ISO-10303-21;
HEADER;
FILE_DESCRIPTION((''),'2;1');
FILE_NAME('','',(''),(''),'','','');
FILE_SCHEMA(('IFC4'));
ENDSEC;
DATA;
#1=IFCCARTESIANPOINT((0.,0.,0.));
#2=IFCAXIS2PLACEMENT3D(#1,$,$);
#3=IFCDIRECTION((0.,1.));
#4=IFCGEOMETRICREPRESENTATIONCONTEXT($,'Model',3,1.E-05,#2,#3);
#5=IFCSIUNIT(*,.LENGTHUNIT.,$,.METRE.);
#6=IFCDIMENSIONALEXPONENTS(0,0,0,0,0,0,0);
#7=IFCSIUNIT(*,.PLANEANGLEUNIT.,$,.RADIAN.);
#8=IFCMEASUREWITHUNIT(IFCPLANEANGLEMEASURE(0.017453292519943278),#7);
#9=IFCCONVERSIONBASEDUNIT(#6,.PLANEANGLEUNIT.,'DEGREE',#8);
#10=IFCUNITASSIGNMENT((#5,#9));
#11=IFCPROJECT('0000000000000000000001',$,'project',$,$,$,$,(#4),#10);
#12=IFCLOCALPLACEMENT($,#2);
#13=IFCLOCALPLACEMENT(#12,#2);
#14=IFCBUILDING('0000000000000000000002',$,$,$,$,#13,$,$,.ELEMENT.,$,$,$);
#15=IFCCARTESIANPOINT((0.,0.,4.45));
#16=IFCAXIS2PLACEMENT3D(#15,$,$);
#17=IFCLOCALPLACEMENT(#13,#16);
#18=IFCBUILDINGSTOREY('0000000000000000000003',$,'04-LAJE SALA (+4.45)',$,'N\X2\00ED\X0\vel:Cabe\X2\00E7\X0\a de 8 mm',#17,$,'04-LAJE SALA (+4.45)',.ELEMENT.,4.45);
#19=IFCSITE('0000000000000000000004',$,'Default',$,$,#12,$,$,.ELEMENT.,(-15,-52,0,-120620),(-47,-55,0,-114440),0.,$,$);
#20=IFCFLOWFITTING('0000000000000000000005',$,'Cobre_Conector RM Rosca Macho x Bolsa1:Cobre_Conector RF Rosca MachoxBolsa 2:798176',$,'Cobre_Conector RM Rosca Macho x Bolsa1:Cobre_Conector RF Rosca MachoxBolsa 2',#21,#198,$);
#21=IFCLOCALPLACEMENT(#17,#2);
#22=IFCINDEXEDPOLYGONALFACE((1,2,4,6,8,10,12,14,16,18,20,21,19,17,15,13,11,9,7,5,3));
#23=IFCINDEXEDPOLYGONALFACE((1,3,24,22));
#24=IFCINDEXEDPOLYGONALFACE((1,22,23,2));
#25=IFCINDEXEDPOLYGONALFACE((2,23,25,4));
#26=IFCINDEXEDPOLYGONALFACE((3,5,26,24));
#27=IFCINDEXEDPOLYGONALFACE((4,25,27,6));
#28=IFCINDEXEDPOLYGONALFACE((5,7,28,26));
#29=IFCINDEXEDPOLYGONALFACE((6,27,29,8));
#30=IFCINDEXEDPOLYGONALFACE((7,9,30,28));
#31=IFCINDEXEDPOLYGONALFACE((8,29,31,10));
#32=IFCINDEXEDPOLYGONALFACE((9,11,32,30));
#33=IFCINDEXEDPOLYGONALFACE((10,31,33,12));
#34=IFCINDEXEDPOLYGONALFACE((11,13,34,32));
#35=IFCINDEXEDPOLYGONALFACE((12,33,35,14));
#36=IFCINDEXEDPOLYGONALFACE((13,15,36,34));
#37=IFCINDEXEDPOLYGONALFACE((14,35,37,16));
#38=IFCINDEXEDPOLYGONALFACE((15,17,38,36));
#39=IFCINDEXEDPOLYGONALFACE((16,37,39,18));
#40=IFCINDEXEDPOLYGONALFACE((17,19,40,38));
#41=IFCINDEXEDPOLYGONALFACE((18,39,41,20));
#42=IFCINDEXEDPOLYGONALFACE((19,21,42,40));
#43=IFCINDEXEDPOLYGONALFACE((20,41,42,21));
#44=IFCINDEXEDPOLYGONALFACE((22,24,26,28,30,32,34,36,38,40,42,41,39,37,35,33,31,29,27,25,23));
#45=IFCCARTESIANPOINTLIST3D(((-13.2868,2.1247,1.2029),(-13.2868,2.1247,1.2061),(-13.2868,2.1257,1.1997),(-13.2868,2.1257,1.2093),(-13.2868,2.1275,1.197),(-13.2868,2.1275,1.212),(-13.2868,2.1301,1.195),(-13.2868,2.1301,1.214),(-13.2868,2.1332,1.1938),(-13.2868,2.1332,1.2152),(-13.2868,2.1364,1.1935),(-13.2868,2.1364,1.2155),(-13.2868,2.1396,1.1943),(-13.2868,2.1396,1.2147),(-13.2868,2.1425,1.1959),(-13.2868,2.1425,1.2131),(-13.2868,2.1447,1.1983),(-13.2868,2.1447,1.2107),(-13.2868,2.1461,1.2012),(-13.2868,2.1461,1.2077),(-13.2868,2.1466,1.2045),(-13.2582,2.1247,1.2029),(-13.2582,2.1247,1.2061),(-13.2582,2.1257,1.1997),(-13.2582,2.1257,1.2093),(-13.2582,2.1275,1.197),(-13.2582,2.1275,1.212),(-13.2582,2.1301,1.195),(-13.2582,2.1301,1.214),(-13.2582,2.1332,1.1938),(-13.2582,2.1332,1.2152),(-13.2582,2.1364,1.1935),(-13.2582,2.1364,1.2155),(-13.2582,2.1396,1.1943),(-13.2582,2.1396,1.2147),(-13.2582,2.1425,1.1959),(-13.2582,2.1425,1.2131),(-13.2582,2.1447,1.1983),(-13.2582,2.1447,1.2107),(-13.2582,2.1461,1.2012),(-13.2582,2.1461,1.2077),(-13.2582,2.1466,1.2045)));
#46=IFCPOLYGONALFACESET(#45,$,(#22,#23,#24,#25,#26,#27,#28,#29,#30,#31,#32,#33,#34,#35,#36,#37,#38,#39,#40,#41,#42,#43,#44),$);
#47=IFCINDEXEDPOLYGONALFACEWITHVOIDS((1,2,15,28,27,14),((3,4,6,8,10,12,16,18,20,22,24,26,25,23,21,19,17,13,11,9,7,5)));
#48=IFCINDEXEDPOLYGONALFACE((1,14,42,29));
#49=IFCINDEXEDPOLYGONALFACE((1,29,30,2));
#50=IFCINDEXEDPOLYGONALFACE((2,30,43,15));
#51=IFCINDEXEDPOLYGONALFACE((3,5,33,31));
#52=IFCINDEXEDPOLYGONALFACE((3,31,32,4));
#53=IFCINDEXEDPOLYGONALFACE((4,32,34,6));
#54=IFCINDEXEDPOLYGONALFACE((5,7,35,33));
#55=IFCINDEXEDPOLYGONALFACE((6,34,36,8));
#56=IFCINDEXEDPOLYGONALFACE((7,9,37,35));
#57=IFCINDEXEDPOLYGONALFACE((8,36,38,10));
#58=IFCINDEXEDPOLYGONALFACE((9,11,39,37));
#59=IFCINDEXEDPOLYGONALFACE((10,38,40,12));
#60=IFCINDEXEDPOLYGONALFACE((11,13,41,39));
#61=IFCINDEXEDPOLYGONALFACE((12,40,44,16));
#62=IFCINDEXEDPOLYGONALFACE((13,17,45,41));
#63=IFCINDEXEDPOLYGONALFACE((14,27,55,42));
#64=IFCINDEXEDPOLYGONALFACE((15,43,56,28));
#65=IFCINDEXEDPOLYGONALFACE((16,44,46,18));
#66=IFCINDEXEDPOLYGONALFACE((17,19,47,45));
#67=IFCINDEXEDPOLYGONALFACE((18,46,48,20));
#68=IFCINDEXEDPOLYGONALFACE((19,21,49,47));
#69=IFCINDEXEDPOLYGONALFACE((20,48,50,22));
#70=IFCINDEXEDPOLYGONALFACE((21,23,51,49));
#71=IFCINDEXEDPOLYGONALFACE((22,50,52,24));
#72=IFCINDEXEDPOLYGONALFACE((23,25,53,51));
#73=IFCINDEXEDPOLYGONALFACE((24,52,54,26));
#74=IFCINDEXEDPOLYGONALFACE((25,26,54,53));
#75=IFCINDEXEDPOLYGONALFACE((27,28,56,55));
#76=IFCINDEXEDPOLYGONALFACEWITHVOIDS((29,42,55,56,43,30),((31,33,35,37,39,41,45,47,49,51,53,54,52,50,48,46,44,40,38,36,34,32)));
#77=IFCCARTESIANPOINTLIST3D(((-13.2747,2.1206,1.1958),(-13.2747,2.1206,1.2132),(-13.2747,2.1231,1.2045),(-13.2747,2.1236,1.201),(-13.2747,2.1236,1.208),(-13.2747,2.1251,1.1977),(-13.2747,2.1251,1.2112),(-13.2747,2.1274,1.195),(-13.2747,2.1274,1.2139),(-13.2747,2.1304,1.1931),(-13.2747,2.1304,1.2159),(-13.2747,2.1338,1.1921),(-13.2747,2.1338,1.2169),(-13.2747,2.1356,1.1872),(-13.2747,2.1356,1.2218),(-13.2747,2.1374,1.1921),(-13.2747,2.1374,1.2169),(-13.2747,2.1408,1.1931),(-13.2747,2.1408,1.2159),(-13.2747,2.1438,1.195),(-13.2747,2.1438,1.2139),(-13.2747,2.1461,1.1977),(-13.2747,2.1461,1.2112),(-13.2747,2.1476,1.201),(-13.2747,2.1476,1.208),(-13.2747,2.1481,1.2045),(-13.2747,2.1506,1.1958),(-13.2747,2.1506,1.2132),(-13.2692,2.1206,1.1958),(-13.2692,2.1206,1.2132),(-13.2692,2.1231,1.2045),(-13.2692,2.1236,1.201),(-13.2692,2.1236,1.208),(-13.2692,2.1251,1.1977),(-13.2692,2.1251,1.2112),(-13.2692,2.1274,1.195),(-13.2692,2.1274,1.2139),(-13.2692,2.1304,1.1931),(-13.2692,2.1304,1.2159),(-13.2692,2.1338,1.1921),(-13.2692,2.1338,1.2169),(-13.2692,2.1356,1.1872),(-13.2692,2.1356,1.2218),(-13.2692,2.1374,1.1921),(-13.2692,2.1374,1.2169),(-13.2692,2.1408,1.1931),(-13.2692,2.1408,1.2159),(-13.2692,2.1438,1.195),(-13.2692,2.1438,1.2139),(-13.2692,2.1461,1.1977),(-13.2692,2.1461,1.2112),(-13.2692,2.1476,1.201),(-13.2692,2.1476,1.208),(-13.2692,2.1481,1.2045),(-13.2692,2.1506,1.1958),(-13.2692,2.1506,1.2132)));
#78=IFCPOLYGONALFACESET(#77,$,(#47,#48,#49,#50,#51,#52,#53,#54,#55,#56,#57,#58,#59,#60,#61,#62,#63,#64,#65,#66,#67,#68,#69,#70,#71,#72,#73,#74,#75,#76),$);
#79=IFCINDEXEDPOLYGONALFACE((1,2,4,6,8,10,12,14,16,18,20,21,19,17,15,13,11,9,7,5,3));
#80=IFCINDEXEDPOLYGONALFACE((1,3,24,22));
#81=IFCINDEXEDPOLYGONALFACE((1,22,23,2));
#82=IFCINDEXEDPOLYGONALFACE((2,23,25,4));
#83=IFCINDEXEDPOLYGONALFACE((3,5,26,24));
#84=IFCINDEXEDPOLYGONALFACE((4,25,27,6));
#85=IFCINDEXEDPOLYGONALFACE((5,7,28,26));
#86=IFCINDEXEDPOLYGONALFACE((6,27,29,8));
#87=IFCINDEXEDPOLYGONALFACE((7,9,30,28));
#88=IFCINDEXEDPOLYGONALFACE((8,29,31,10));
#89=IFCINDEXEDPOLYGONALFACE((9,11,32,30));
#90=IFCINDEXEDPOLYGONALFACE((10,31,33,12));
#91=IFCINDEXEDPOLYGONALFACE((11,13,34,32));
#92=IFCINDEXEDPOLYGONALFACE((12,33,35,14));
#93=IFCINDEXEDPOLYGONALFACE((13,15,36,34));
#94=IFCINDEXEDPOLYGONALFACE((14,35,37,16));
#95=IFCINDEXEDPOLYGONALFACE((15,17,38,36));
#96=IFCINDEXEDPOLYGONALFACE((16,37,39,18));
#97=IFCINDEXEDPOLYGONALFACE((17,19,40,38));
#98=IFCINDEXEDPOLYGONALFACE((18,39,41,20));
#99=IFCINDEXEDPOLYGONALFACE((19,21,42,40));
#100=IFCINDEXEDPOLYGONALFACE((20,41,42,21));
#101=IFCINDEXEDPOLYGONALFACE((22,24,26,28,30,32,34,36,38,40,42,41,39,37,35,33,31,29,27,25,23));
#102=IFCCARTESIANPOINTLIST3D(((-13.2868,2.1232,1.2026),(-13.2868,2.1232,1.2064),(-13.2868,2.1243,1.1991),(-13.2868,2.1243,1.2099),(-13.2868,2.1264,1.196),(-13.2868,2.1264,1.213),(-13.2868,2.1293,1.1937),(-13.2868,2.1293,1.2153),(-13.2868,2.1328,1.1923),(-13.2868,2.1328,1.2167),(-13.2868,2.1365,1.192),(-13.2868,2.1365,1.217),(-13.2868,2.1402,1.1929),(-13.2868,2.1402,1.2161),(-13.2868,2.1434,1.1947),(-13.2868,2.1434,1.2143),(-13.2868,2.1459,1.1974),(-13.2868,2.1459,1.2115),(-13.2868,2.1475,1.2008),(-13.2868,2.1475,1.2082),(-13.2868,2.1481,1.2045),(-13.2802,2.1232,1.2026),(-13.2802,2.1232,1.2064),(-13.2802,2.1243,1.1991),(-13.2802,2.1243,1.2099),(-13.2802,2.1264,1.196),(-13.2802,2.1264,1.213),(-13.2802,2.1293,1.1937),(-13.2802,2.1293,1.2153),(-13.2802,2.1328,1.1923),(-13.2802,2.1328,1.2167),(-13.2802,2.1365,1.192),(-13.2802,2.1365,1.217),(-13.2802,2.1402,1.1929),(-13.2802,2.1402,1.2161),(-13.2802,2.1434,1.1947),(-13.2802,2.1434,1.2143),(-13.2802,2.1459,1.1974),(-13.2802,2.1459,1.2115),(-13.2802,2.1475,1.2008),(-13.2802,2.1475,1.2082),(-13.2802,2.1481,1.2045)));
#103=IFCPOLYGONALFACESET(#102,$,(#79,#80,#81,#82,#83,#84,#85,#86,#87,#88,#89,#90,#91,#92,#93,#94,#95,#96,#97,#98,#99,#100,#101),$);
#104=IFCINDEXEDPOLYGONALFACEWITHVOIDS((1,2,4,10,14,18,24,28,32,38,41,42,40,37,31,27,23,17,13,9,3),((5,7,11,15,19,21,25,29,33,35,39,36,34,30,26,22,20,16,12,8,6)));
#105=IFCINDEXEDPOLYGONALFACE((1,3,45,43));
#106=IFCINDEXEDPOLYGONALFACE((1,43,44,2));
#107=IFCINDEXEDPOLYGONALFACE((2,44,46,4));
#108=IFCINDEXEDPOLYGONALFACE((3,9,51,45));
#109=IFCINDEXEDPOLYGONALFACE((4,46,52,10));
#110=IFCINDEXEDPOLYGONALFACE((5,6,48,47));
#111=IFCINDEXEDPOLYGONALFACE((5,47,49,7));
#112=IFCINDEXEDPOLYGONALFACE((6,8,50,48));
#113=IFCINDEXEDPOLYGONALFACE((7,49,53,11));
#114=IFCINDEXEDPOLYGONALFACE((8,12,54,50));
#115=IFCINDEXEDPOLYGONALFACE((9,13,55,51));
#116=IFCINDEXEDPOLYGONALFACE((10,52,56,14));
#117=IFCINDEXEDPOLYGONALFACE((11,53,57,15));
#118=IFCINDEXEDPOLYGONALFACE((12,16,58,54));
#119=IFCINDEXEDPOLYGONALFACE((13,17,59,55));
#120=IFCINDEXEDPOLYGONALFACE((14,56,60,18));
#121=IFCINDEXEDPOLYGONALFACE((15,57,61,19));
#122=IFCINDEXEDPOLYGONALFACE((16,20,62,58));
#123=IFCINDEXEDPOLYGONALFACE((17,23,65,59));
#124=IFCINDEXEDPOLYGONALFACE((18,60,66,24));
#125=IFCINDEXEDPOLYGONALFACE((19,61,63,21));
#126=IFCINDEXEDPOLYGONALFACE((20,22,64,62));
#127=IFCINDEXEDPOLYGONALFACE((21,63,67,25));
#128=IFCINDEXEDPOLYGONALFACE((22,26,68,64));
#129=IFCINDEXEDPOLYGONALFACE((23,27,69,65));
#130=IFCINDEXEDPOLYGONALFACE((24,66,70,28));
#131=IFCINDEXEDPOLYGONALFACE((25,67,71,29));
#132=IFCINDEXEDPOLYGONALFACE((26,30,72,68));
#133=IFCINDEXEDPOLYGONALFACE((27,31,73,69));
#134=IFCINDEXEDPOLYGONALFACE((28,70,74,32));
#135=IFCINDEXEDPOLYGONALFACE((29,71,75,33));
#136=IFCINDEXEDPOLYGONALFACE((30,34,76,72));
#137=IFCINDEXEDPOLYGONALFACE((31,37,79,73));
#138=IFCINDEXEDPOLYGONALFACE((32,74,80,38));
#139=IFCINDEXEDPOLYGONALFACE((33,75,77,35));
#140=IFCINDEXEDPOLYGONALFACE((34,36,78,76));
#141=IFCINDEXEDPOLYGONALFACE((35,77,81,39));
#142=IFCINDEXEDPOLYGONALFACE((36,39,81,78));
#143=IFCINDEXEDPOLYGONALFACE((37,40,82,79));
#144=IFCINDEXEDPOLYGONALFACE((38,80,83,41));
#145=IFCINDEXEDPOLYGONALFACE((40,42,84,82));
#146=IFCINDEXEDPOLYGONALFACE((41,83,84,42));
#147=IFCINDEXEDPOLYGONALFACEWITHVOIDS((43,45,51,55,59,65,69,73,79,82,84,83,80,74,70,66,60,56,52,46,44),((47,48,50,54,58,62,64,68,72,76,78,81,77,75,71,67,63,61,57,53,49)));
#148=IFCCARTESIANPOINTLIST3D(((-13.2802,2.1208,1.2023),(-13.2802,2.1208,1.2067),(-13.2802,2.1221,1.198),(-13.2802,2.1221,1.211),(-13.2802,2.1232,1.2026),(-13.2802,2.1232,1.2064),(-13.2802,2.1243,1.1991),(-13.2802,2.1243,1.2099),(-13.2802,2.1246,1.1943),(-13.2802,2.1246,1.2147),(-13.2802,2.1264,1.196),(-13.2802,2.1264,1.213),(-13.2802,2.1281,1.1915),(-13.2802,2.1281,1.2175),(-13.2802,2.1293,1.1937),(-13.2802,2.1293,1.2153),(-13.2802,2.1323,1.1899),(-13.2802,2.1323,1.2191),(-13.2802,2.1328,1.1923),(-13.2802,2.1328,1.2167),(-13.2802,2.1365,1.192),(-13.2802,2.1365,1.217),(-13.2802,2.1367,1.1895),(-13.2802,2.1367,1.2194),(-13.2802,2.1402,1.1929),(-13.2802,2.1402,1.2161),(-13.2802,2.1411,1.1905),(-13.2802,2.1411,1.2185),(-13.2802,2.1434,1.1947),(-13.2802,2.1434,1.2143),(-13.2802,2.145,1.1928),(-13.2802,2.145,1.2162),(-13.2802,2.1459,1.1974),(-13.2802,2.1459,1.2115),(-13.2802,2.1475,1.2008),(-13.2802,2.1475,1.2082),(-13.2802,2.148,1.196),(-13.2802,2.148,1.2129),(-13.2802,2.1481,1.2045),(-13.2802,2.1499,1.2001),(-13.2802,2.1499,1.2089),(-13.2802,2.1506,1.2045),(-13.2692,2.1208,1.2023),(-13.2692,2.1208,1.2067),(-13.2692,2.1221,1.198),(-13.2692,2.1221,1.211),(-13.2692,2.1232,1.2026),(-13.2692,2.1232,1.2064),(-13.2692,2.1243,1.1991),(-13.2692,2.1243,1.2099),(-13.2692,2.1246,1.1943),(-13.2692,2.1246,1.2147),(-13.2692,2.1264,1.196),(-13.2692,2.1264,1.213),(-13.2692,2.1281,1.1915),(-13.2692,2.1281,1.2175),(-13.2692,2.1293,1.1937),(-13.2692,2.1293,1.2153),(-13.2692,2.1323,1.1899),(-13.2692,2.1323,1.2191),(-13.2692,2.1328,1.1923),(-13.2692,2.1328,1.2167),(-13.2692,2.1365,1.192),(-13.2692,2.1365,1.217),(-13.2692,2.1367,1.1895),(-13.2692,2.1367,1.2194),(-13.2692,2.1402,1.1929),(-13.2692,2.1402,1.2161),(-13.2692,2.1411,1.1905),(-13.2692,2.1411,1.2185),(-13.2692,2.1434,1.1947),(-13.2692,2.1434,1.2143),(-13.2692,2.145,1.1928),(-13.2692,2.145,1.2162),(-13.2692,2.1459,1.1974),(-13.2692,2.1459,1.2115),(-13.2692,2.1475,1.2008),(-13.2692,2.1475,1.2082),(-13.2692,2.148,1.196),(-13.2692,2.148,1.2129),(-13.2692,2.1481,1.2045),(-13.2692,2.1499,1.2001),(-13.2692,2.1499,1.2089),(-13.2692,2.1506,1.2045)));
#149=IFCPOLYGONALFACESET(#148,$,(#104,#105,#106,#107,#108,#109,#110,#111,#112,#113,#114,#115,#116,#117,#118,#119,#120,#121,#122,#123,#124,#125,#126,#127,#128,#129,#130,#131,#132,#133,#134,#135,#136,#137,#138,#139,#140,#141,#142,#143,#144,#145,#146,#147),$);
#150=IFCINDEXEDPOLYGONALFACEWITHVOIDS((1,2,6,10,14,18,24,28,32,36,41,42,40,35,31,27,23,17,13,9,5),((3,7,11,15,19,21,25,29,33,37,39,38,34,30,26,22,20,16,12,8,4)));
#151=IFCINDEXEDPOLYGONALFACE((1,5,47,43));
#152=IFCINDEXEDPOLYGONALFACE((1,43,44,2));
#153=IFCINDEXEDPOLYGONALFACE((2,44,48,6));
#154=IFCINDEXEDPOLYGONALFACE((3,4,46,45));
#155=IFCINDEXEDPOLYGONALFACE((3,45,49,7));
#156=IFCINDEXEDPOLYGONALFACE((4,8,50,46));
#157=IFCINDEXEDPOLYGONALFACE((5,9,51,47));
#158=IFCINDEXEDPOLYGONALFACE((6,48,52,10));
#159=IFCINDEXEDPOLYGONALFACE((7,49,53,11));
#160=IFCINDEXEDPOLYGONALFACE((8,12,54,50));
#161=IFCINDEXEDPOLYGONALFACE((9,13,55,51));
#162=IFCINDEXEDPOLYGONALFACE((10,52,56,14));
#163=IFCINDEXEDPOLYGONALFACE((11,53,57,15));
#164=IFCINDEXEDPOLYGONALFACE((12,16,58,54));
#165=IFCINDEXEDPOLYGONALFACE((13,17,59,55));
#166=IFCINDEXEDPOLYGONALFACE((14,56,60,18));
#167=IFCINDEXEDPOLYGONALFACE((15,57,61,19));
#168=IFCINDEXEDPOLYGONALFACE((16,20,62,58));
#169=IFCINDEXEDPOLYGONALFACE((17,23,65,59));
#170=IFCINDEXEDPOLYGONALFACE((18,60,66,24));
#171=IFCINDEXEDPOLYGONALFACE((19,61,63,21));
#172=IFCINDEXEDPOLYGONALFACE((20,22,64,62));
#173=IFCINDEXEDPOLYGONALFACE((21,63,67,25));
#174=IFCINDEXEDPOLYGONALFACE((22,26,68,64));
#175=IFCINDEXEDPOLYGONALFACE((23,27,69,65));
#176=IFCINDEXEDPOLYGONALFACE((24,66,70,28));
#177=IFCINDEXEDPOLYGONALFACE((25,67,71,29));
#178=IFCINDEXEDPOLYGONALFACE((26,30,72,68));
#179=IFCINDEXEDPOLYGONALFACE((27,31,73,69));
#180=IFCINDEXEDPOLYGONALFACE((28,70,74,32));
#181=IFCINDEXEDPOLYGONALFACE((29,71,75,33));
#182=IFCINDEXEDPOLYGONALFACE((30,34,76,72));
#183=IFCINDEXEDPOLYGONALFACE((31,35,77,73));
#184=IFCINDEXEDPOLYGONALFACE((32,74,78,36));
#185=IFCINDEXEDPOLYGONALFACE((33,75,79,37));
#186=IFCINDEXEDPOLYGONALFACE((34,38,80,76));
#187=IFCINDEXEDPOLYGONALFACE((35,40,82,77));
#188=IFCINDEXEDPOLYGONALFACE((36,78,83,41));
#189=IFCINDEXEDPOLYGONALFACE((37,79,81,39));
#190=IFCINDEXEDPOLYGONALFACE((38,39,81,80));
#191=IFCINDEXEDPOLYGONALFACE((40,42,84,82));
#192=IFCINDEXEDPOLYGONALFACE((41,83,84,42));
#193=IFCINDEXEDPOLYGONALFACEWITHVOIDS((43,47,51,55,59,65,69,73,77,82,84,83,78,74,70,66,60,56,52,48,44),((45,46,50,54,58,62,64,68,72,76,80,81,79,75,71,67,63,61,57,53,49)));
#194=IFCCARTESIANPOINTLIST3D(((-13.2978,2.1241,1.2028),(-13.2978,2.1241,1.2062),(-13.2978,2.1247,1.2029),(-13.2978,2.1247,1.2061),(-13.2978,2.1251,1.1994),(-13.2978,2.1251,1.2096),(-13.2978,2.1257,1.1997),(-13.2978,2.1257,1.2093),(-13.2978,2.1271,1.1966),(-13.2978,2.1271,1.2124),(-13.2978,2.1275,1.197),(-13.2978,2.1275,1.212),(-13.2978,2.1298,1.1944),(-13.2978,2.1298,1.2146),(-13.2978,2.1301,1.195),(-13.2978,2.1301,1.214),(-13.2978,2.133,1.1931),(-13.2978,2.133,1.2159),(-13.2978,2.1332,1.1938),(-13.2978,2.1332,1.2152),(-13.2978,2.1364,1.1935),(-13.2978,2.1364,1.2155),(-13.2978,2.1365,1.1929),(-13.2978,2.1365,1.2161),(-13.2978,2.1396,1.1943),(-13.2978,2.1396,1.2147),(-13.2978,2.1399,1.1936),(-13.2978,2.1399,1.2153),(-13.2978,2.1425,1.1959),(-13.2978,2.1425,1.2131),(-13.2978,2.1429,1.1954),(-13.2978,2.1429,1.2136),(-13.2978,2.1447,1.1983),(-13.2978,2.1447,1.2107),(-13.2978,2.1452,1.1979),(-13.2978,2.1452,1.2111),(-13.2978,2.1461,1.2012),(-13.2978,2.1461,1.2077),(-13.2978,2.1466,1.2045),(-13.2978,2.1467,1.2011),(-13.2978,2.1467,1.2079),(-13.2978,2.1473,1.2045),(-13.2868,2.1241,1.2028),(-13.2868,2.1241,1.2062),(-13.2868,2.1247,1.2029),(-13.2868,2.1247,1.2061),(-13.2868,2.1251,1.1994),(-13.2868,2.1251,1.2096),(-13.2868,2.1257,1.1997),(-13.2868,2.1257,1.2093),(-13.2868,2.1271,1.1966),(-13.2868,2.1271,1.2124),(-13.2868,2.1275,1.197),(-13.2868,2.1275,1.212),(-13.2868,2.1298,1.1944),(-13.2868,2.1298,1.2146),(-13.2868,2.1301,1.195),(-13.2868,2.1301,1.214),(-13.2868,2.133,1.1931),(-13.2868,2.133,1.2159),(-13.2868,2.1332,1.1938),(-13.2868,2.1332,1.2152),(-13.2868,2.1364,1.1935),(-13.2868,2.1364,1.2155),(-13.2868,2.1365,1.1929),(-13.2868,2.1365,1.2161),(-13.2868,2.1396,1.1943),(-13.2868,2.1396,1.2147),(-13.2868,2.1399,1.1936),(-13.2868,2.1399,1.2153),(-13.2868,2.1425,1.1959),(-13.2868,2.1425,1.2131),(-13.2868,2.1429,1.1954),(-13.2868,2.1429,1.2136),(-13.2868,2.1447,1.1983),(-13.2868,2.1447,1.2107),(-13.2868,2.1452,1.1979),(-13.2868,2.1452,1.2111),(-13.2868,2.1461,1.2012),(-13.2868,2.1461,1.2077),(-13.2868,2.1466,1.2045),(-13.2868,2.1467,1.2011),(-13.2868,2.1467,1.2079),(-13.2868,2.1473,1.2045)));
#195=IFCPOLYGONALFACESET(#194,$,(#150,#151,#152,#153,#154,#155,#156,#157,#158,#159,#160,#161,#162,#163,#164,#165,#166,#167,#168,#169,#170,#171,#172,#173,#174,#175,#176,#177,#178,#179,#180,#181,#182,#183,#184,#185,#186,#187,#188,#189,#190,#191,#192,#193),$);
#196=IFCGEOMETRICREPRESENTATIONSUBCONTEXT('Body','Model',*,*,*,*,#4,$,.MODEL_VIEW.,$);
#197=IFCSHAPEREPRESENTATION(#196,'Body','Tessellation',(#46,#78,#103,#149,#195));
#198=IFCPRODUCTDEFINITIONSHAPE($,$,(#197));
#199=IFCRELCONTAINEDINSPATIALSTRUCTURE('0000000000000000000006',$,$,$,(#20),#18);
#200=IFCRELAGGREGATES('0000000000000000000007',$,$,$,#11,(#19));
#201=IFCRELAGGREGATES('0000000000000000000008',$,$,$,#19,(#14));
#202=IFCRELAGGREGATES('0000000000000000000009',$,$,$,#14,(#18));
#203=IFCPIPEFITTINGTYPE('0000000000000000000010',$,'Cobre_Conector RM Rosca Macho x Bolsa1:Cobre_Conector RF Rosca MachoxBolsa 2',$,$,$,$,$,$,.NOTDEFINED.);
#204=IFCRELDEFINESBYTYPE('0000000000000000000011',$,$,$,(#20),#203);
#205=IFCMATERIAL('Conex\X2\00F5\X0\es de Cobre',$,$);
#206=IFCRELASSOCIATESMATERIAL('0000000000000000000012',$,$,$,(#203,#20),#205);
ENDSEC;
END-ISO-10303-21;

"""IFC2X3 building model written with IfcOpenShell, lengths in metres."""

from ifc_helpers import new_model, entity, si_unit, converted_unit, direction, frame, frame_2d, origin, place, context, subcontext, project, spatial, polyline, circle_curve, parameter, trimmed, segment, composite_curve, circle, hollow_circle, outline, extrude, source, transform, mapped, material, type_object, type_shapes, element, save


model = new_model("IFC2X3")

# Units and contexts
model_context = context("Model", 3, precision=1e-05, world=origin(), true_north=direction((0.0, 1.0)))
body_context = subcontext(model_context, "Body", "Model", "MODEL_VIEW")
ifc_project = project(units=[si_unit("LENGTHUNIT", "METRE"), converted_unit("PLANEANGLEUNIT", "DEGREE", entity("IfcPlaneAngleMeasure", 0.017453292519943278), si_unit("PLANEANGLEUNIT", "RADIAN"), dimensions=[0, 0, 0, 0, 0, 0, 0])], contexts=[model_context])

# Site, building, storey
site_placement = place(None, origin())
site = spatial("IfcSite", under=ifc_project, at=site_placement, Name="Default", CompositionType="ELEMENT", RefLatitude=(-15, -52, 0, -120620), RefLongitude=(-47, -55, 0, -114440), RefElevation=0.0)
building_placement = place(site_placement, origin())
building = spatial("IfcBuilding", under=site, at=building_placement, CompositionType="ELEMENT")
storey_placement = place(building_placement, frame((0.0, 0.0, 4.45)))
storey = spatial("IfcBuildingStorey", under=building, at=storey_placement, Name="04-LAJE SALA (+4.45)", ObjectType="Nível:Cabeça de 8 mm", LongName="04-LAJE SALA (+4.45)", CompositionType="ELEMENT", Elevation=4.45)

# Flow fitting
ifc_material_1 = material(Name="Conexões de Cobre")
pipe_fitting_type_1 = type_object("IfcPipeFittingType", Name="Cobre_Conector RM Rosca Macho x Bolsa1:Cobre_Conector RF Rosca MachoxBolsa 2", PredefinedType="NOTDEFINED", material=ifc_material_1)
shared_shape_1 = source(origin(), body_context, "Body", "SweptSolid", [
    extrude(circle(Radius=0.011, at=frame_2d((0.0, 0.0), x_axis=(1.0, 0.0))), frame((0.011, 0.0, 0.0), z_axis=(1.0, 0.0, 0.0), x_axis=(0.0, 1.0, 0.0)), (0.0, 0.0, 1.0), 0.0286),
    extrude(outline(polyline([(-0.0087, -0.015), (0.0087, -0.015), (0.0173, 0.0), (0.0087, 0.015), (-0.0087, 0.015), (-0.0173, 0.0), (-0.0087, -0.015)]), holes=[composite_curve([segment(trimmed(circle_curve(frame_2d((0.0, 0.0), x_axis=(0.0, 1.0)), 0.0125), [parameter(0.0)], [parameter(180.0)], True, "PARAMETER"), False, "CONTINUOUS"), segment(trimmed(circle_curve(frame_2d((0.0, 0.0), x_axis=(0.0, 1.0)), 0.0125), [parameter(180.0)], [parameter(0.0)], True, "PARAMETER"), False, "CONTINUOUS")], self_intersect=False)]), frame((0.0231, 0.0, 0.0), z_axis=(1.0, 0.0, 0.0), x_axis=(0.0, 0.0, -1.0)), (0.0, 0.0, 1.0), 0.0055),
    extrude(circle(Radius=0.0125, at=frame_2d((0.0, 0.0), x_axis=(1.0, 0.0))), frame((0.011, 0.0, 0.0), z_axis=(1.0, 0.0, 0.0), x_axis=(0.0, 1.0, 0.0)), (0.0, 0.0, 1.0), 0.0066),
    extrude(hollow_circle(Radius=0.015, WallThickness=0.0025, at=frame_2d((0.0, 0.0), x_axis=(1.0, 0.0))), frame((0.0176, 0.0, 0.0), z_axis=(1.0, 0.0, 0.0), x_axis=(0.0, 1.0, 0.0)), (0.0, 0.0, 1.0), 0.011),
    extrude(hollow_circle(Radius=0.0117, WallThickness=0.0007, at=frame_2d((0.0, 0.0), x_axis=(1.0, 0.0))), frame((0.0, 0.0, 0.0), z_axis=(1.0, 0.0, 0.0), x_axis=(0.0, 1.0, 0.0)), (0.0, 0.0, 1.0), 0.011),
])
type_shapes(pipe_fitting_type_1, [shared_shape_1])
flow_fitting_1_placement = place(storey_placement, frame((-13.2978, 2.1356, 1.2045)))
element("IfcFlowFitting", 1, at=flow_fitting_1_placement, inside=storey, type_object=pipe_fitting_type_1, material=ifc_material_1, Name="Cobre_Conector RM Rosca Macho x Bolsa1:Cobre_Conector RF Rosca MachoxBolsa 2:798176", ObjectType="Cobre_Conector RM Rosca Macho x Bolsa1:Cobre_Conector RF Rosca MachoxBolsa 2", context=body_context, shape_type="MappedRepresentation", body=[
    mapped(shared_shape_1, transform((0.0, 0.0, 0.0), scale=1.0)),
])

save(model, "model.ifc")
